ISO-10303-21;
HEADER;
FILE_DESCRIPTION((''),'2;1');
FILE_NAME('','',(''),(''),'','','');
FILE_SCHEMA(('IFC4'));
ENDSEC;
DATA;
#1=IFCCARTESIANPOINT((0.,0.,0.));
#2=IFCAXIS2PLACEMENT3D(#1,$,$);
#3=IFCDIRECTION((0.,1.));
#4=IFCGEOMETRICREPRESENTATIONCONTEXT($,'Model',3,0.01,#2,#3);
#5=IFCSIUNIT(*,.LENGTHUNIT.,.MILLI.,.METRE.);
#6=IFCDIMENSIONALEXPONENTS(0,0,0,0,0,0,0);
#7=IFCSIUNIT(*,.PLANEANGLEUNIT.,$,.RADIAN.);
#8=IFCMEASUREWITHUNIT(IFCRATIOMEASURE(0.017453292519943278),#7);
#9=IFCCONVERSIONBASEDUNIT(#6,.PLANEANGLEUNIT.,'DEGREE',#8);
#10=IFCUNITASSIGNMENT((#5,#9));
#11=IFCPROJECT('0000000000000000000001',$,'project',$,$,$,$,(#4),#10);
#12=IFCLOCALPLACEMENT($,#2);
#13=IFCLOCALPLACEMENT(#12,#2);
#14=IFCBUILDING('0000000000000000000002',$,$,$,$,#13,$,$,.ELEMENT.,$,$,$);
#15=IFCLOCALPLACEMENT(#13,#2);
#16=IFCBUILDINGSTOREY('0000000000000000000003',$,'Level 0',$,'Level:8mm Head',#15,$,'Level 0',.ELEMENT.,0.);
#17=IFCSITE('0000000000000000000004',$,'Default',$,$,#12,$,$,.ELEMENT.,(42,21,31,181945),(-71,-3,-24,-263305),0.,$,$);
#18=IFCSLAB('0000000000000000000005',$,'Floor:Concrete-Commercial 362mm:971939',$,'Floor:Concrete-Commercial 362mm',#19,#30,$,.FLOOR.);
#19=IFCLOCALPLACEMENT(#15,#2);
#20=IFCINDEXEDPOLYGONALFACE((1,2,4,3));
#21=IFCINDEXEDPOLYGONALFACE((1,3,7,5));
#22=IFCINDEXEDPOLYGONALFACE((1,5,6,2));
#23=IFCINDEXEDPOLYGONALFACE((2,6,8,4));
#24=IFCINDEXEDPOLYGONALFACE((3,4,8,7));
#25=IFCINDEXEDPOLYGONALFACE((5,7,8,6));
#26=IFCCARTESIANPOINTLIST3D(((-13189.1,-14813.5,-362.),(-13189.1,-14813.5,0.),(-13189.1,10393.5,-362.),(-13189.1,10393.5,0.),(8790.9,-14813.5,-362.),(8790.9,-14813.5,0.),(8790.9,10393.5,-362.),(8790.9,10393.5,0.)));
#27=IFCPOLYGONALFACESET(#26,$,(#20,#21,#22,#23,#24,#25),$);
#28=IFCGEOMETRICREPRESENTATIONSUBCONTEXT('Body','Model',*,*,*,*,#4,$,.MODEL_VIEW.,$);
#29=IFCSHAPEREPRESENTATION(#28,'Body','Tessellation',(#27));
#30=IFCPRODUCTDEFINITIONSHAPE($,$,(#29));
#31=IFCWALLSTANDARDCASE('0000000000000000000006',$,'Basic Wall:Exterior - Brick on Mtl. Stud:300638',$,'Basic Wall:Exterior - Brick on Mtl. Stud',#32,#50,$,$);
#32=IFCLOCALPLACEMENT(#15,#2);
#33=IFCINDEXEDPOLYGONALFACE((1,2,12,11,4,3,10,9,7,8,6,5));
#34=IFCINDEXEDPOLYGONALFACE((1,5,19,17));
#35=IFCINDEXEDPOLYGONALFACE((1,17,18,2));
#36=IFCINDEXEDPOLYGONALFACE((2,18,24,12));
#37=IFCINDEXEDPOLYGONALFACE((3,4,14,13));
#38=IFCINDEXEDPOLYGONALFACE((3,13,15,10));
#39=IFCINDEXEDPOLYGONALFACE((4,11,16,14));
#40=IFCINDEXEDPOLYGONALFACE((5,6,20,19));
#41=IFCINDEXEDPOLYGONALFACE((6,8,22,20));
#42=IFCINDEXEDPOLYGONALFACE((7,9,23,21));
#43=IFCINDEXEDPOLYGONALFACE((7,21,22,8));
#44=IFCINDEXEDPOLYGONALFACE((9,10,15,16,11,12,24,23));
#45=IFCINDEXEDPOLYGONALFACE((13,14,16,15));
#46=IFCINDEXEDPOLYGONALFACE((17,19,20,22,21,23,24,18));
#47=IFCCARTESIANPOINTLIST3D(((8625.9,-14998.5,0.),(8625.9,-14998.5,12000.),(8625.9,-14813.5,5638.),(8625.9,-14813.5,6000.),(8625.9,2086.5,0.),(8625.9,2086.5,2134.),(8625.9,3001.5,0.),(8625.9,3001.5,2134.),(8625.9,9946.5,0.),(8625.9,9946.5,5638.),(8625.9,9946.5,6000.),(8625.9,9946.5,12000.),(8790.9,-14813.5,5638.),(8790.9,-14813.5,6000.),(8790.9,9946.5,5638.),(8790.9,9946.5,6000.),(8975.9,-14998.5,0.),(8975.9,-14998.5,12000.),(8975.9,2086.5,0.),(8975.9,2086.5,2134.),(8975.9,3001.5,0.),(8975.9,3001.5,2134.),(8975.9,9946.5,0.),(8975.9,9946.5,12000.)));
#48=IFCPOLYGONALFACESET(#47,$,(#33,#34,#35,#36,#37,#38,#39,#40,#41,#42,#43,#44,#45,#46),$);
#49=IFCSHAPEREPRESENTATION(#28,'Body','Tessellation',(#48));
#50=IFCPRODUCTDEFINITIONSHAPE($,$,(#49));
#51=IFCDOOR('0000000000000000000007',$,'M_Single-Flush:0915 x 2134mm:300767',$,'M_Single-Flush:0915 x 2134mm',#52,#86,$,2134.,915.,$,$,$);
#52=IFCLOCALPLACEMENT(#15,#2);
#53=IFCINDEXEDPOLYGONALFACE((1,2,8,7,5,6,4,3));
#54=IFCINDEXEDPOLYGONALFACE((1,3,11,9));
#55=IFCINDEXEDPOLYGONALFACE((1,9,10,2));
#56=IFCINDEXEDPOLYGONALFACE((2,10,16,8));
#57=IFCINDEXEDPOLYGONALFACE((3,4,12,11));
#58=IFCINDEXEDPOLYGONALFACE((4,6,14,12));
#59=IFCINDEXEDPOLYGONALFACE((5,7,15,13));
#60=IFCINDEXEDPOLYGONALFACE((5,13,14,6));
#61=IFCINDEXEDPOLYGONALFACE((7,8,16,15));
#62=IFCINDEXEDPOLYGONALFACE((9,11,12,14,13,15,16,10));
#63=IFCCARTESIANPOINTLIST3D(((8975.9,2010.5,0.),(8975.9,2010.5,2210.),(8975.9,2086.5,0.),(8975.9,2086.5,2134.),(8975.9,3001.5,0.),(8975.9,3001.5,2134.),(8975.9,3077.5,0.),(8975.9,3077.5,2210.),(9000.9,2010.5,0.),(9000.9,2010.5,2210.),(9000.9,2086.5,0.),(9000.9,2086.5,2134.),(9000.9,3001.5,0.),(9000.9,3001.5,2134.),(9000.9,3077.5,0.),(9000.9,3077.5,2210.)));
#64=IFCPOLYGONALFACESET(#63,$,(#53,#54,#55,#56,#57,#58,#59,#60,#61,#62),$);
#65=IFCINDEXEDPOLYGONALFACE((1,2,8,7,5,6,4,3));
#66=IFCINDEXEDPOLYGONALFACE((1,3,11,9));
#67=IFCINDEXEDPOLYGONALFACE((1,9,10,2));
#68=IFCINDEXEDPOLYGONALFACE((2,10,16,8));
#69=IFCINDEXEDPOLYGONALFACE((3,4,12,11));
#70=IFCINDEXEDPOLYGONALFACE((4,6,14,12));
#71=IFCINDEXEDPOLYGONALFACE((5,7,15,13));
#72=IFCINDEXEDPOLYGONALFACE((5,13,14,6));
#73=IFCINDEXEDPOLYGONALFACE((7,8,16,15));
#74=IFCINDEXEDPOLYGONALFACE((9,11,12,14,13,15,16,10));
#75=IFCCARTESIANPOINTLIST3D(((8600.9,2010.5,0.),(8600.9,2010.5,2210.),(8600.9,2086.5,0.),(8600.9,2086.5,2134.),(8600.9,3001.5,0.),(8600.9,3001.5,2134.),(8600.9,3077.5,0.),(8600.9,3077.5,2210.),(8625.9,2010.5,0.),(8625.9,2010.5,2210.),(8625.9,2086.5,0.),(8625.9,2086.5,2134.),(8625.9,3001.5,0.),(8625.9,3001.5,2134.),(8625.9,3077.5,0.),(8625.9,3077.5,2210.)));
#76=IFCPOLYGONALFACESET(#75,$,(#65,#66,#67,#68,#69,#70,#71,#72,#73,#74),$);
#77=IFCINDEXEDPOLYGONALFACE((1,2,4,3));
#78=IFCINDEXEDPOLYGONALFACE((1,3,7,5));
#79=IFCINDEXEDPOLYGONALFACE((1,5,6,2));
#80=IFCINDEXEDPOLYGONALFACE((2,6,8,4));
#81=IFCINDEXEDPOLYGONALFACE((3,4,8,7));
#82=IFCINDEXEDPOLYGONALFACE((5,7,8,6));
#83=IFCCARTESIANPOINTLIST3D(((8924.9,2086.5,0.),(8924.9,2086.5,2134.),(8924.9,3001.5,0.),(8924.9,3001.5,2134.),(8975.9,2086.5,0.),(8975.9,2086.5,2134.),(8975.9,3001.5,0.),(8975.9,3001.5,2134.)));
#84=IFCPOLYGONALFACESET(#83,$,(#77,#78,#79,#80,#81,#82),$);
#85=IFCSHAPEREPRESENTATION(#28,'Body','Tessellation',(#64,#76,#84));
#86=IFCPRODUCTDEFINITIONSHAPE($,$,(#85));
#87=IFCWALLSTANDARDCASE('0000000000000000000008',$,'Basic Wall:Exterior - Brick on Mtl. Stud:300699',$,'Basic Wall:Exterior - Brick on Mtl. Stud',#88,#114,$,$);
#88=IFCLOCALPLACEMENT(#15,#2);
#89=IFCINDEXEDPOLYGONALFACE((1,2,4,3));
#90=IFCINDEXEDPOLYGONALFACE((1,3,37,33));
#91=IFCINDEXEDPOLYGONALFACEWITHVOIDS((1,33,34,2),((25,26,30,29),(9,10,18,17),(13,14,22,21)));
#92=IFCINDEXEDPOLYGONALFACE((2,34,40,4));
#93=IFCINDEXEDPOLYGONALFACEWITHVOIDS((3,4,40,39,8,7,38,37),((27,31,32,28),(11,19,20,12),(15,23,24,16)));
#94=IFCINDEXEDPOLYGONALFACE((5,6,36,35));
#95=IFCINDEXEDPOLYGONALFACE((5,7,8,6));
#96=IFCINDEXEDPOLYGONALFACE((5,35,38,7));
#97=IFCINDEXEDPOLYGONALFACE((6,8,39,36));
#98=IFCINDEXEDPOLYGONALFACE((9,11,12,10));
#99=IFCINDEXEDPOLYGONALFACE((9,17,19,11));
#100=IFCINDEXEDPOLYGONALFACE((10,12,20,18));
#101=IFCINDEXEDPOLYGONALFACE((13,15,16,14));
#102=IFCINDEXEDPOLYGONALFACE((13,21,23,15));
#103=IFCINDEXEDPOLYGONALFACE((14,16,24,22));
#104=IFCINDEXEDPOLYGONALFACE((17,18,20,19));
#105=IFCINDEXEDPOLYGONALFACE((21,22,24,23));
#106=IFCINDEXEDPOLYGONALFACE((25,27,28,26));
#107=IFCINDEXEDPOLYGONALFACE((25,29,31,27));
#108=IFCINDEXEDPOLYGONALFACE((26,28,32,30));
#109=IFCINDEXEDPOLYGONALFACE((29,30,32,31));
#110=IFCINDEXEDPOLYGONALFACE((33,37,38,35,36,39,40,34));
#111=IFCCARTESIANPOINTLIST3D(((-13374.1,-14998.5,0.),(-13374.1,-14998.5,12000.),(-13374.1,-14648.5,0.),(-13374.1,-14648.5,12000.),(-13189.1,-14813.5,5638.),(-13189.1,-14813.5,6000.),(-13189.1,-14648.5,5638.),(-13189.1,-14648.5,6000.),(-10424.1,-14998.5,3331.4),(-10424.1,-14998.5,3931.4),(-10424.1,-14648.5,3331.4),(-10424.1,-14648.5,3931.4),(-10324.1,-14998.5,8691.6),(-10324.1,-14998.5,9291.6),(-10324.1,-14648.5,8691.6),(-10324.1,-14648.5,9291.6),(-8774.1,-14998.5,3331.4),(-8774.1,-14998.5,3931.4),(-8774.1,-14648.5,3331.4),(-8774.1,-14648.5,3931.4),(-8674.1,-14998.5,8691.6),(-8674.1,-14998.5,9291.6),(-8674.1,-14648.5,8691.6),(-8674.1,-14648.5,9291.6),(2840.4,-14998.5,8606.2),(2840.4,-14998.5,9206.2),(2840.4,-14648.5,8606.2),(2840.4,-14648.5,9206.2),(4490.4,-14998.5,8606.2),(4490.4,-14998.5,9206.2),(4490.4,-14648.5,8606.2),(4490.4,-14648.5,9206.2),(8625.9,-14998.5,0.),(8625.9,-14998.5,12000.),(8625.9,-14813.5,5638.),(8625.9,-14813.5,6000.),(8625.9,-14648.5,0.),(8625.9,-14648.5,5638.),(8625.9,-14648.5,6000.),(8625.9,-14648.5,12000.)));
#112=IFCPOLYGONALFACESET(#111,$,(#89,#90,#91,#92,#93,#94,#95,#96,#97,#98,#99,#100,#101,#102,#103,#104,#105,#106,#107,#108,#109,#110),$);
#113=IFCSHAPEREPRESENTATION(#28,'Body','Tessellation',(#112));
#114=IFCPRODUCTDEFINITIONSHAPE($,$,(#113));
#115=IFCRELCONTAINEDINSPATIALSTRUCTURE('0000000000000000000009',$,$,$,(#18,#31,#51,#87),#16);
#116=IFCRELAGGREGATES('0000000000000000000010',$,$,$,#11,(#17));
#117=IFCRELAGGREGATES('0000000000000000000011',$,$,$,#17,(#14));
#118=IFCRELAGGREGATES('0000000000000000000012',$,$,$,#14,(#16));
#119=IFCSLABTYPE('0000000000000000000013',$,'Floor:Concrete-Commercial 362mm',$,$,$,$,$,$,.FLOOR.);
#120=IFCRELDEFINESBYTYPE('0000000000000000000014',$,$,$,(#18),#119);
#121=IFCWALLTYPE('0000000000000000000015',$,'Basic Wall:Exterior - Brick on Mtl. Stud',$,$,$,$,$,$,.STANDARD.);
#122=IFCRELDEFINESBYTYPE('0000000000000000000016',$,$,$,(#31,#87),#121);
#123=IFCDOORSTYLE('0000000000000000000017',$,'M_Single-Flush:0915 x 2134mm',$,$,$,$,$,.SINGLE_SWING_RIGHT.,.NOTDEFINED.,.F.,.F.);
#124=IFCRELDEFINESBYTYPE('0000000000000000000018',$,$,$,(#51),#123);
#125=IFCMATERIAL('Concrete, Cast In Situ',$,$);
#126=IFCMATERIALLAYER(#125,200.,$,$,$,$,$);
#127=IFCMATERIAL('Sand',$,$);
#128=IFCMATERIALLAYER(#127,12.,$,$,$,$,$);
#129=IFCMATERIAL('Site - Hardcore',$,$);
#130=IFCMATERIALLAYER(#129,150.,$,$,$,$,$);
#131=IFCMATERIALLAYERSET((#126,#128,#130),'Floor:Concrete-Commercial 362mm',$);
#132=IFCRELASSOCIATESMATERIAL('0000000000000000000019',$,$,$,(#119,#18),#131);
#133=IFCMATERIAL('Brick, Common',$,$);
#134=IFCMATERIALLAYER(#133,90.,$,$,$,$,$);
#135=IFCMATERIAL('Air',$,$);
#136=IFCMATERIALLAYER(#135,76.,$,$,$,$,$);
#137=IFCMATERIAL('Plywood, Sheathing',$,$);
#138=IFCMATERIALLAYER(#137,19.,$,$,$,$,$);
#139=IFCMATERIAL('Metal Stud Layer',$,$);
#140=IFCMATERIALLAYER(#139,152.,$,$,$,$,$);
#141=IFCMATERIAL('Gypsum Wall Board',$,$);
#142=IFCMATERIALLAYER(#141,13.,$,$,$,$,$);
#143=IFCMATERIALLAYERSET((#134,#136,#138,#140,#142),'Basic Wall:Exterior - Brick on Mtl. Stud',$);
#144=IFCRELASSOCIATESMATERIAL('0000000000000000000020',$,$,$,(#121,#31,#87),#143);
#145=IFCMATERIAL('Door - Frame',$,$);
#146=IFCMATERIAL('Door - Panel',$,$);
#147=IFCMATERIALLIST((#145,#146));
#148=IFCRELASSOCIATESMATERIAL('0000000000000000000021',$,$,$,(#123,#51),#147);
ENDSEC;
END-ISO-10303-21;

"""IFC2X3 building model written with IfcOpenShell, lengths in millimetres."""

from ifc_helpers import new_model, entity, si_unit, converted_unit, direction, frame, frame_2d, origin, place, context, subcontext, project, spatial, polyline, rectangle, outline, extrude, source, transform, mapped, material, material_list, layer, layer_set, layer_usage, type_object, type_shapes, element, fill, save


model = new_model("IFC2X3")

# Units and contexts
model_context = context("Model", 3, precision=0.01, world=origin(), true_north=direction((0.0, 1.0)))
body_context = subcontext(model_context, "Body", "Model", "MODEL_VIEW")
ifc_project = project(units=[si_unit("LENGTHUNIT", "METRE", prefix="MILLI"), converted_unit("PLANEANGLEUNIT", "DEGREE", entity("IfcRatioMeasure", 0.017453292519943278), si_unit("PLANEANGLEUNIT", "RADIAN"), dimensions=[0, 0, 0, 0, 0, 0, 0])], contexts=[model_context])

# Site, building, storey
site_placement = place(None, origin())
site = spatial("IfcSite", under=ifc_project, at=site_placement, Name="Default", CompositionType="ELEMENT", RefLatitude=(42, 21, 31, 181945), RefLongitude=(-71, -3, -24, -263305), RefElevation=0.0)
building_placement = place(site_placement, origin())
building = spatial("IfcBuilding", under=site, at=building_placement, CompositionType="ELEMENT")
storey_placement = place(building_placement, origin())
storey = spatial("IfcBuildingStorey", under=building, at=storey_placement, Name="Level 0", ObjectType="Level:8mm Head", LongName="Level 0", CompositionType="ELEMENT", Elevation=0.0)

# Slab
ifc_material_1 = material(Name="Concrete, Cast In Situ")
ifc_layer_1 = layer(ifc_material_1, 200.0)
ifc_material_2 = material(Name="Sand")
ifc_layer_2 = layer(ifc_material_2, 12.0)
ifc_material_3 = material(Name="Site - Hardcore")
ifc_layer_3 = layer(ifc_material_3, 150.0)
ifc_layer_set_1 = layer_set([ifc_layer_1, ifc_layer_2, ifc_layer_3], Name="Floor:Concrete-Commercial 362mm")
ifc_layer_usage_1 = layer_usage(ifc_layer_set_1, "AXIS3", "POSITIVE", 0.0)
slab_type = type_object("IfcSlabType", Name="Floor:Concrete-Commercial 362mm", PredefinedType="FLOOR", material=ifc_layer_set_1)
slab_placement = place(storey_placement, origin())
element("IfcSlab", 1, at=slab_placement, inside=storey, type_object=slab_type, material=ifc_layer_usage_1, Name="Floor:Concrete-Commercial 362mm:971939", ObjectType="Floor:Concrete-Commercial 362mm", PredefinedType="FLOOR", context=body_context, shape_type="SweptSolid", body=[
    extrude(rectangle(XDim=25207.0, YDim=21980.0, at=frame_2d((0.0, 0.0), x_axis=(1.0, 0.0))), frame((-2199.1, -2210.0, 0.0), z_axis=(0.0, 0.0, -1.0), x_axis=(0.0, 1.0, 0.0)), (0.0, 0.0, 1.0), 362.0),
])

# Wall, openings, door
ifc_material_4 = material(Name="Brick, Common")
ifc_layer_4 = layer(ifc_material_4, 90.0)
ifc_material_5 = material(Name="Air")
ifc_layer_5 = layer(ifc_material_5, 76.0)
ifc_material_6 = material(Name="Plywood, Sheathing")
ifc_layer_6 = layer(ifc_material_6, 19.0)
ifc_material_7 = material(Name="Metal Stud Layer")
ifc_layer_7 = layer(ifc_material_7, 152.0)
ifc_material_8 = material(Name="Gypsum Wall Board")
ifc_layer_8 = layer(ifc_material_8, 13.0)
ifc_layer_set_2 = layer_set([ifc_layer_4, ifc_layer_5, ifc_layer_6, ifc_layer_7, ifc_layer_8], Name="Basic Wall:Exterior - Brick on Mtl. Stud")
ifc_layer_usage_2 = layer_usage(ifc_layer_set_2, "AXIS2", "NEGATIVE", 175.0)
wall_type_1 = type_object("IfcWallType", Name="Basic Wall:Exterior - Brick on Mtl. Stud", PredefinedType="STANDARD", material=ifc_layer_set_2)
wall_1_placement = place(storey_placement, frame((8800.9, 9946.5, 0.0), z_axis=(0.0, 0.0, 1.0), x_axis=(0.0, -1.0, 0.0)))
wall_1 = element("IfcWallStandardCase", 2, at=wall_1_placement, inside=storey, type_object=wall_type_1, material=ifc_layer_usage_2, Name="Basic Wall:Exterior - Brick on Mtl. Stud:300638", ObjectType="Basic Wall:Exterior - Brick on Mtl. Stud", context=body_context, shape_type="SweptSolid", body=[
    extrude(rectangle(XDim=24945.0, YDim=350.0, at=frame_2d((12472.5, 0.0), x_axis=(-1.0, 0.0))), origin(), (0.0, 0.0, 1.0), 12000.0),
])
opening_1_placement = place(storey_placement, frame((8800.9, 9946.5, 0.0), z_axis=(0.0, 0.0, 1.0), x_axis=(0.0, -1.0, 0.0)))
element("IfcOpeningElement", 3, at=opening_1_placement, cuts=wall_1, ObjectType="Opening", context=body_context, shape_type="SweptSolid", body=[
    extrude(rectangle(XDim=165.0, YDim=24760.0, at=frame_2d((16.5, 2443.0), x_axis=(1.0, 0.0))), frame((14823.0, -109.0, 5638.0), z_axis=(0.0, 0.0, 1.0), x_axis=(0.0, 1.0, 0.0)), (0.0, 0.0, 1.0), 362.0),
])
opening_2_placement = place(wall_1_placement, frame((6945.0, -175.0, 0.0)))
opening_2 = element("IfcOpeningElement", 4, at=opening_2_placement, cuts=wall_1, ObjectType="Opening", context=body_context, shape_type="SweptSolid", body=[
    extrude(rectangle(XDim=915.0, YDim=2134.0, at=frame_2d((1067.0, 457.5), x_axis=(0.0, 1.0))), frame((0.0, 0.0, 0.0), z_axis=(0.0, 1.0, 0.0), x_axis=(0.0, 0.0, 1.0)), (0.0, 0.0, 1.0), 350.0),
])
ifc_material_9 = material(Name="Door - Frame")
ifc_material_10 = material(Name="Door - Panel")
ifc_material_list_1 = material_list([ifc_material_9, ifc_material_10])
door_style_1 = type_object("IfcDoorStyle", Name="M_Single-Flush:0915 x 2134mm", ConstructionType="NOTDEFINED", OperationType="SINGLE_SWING_RIGHT", ParameterTakesPrecedence=False, Sizeable=False, material=ifc_material_list_1)
shared_shape_1 = source(origin(), body_context, "Body", "SweptSolid", [
    extrude(outline(polyline([(-533.5, -1124.0), (533.5, -1124.0), (533.5, 1086.0), (457.5, 1086.0), (457.5, -1048.0), (-457.5, -1048.0), (-457.5, 1086.0), (-533.5, 1086.0), (-533.5, -1124.0)])), frame((457.5, 350.0, 1086.0), z_axis=(0.0, 1.0, 0.0), x_axis=(1.0, 0.0, 0.0)), (0.0, 0.0, 1.0), 25.0),
    extrude(outline(polyline([(-1124.0, -533.5), (1086.0, -533.5), (1086.0, -457.5), (-1048.0, -457.5), (-1048.0, 457.5), (1086.0, 457.5), (1086.0, 533.5), (-1124.0, 533.5), (-1124.0, -533.5)])), frame((457.5, -25.0, 1086.0), z_axis=(0.0, 1.0, 0.0), x_axis=(0.0, 0.0, -1.0)), (0.0, 0.0, 1.0), 25.0),
    extrude(rectangle(XDim=51.0, YDim=915.0, at=frame_2d((0.0, 0.0), x_axis=(1.0, 0.0))), frame((457.5, 324.5, 0.0), z_axis=(0.0, 0.0, 1.0), x_axis=(0.0, 1.0, 0.0)), (0.0, 0.0, 1.0), 2134.0),
])
type_shapes(door_style_1, [shared_shape_1])
door_1_placement = place(opening_2_placement, origin())
door_1 = element("IfcDoor", 5, at=door_1_placement, inside=storey, type_object=door_style_1, material=ifc_material_list_1, Name="M_Single-Flush:0915 x 2134mm:300767", ObjectType="M_Single-Flush:0915 x 2134mm", OverallHeight=2134.0, OverallWidth=915.0, context=body_context, shape_type="MappedRepresentation", body=[
    mapped(shared_shape_1, transform((0.0, 0.0, 0.0), scale=1.0)),
])
fill(opening_2, door_1)

# Wall, openings
wall_2_placement = place(storey_placement, frame((8625.9, -14823.5, 0.0), z_axis=(0.0, 0.0, 1.0), x_axis=(-1.0, 0.0, 0.0)))
wall_2 = element("IfcWallStandardCase", 6, at=wall_2_placement, inside=storey, type_object=wall_type_1, material=ifc_layer_usage_2, Name="Basic Wall:Exterior - Brick on Mtl. Stud:300699", ObjectType="Basic Wall:Exterior - Brick on Mtl. Stud", context=body_context, shape_type="SweptSolid", body=[
    extrude(rectangle(XDim=22000.0, YDim=350.0, at=frame_2d((11000.0, 0.0), x_axis=(-1.0, 0.0))), origin(), (0.0, 0.0, 1.0), 12000.0),
])
opening_3_placement = place(storey_placement, frame((8625.9, -14823.5, 0.0), z_axis=(0.0, 0.0, 1.0), x_axis=(-1.0, 0.0, 0.0)))
element("IfcOpeningElement", 7, at=opening_3_placement, cuts=wall_2, ObjectType="Opening", context=body_context, shape_type="SweptSolid", body=[
    extrude(rectangle(XDim=165.0, YDim=21815.0, at=frame_2d((35.4, 82.5), x_axis=(1.0, 0.0))), frame((10990.0, -127.9, 5638.0), z_axis=(0.0, 0.0, 1.0), x_axis=(0.0, 1.0, 0.0)), (0.0, 0.0, 1.0), 362.0),
])
opening_4_placement = place(wall_2_placement, frame((17300.0, -175.0, 8691.6)))
element("IfcOpeningElement", 8, at=opening_4_placement, cuts=wall_2, ObjectType="Opening", context=body_context, shape_type="SweptSolid", body=[
    extrude(rectangle(XDim=600.0, YDim=1650.0, at=frame_2d((300.0, 825.0), x_axis=(-1.0, 0.0))), frame((0.0, 0.0, 0.0), z_axis=(0.0, 1.0, 0.0), x_axis=(0.0, 0.0, 1.0)), (0.0, 0.0, 1.0), 350.0),
])
opening_5_placement = place(wall_2_placement, frame((4135.5, -175.0, 8606.2)))
element("IfcOpeningElement", 9, at=opening_5_placement, cuts=wall_2, ObjectType="Opening", context=body_context, shape_type="SweptSolid", body=[
    extrude(rectangle(XDim=600.0, YDim=1650.0, at=frame_2d((300.0, 825.0), x_axis=(-1.0, 0.0))), frame((0.0, 0.0, 0.0), z_axis=(0.0, 1.0, 0.0), x_axis=(0.0, 0.0, 1.0)), (0.0, 0.0, 1.0), 350.0),
])
opening_6_placement = place(wall_2_placement, frame((17400.0, -175.0, 3331.4)))
element("IfcOpeningElement", 10, at=opening_6_placement, cuts=wall_2, ObjectType="Opening", context=body_context, shape_type="SweptSolid", body=[
    extrude(rectangle(XDim=600.0, YDim=1650.0, at=frame_2d((300.0, 825.0), x_axis=(-1.0, 0.0))), frame((0.0, 0.0, 0.0), z_axis=(0.0, 1.0, 0.0), x_axis=(0.0, 0.0, 1.0)), (0.0, 0.0, 1.0), 350.0),
])

save(model, "model.ifc")
